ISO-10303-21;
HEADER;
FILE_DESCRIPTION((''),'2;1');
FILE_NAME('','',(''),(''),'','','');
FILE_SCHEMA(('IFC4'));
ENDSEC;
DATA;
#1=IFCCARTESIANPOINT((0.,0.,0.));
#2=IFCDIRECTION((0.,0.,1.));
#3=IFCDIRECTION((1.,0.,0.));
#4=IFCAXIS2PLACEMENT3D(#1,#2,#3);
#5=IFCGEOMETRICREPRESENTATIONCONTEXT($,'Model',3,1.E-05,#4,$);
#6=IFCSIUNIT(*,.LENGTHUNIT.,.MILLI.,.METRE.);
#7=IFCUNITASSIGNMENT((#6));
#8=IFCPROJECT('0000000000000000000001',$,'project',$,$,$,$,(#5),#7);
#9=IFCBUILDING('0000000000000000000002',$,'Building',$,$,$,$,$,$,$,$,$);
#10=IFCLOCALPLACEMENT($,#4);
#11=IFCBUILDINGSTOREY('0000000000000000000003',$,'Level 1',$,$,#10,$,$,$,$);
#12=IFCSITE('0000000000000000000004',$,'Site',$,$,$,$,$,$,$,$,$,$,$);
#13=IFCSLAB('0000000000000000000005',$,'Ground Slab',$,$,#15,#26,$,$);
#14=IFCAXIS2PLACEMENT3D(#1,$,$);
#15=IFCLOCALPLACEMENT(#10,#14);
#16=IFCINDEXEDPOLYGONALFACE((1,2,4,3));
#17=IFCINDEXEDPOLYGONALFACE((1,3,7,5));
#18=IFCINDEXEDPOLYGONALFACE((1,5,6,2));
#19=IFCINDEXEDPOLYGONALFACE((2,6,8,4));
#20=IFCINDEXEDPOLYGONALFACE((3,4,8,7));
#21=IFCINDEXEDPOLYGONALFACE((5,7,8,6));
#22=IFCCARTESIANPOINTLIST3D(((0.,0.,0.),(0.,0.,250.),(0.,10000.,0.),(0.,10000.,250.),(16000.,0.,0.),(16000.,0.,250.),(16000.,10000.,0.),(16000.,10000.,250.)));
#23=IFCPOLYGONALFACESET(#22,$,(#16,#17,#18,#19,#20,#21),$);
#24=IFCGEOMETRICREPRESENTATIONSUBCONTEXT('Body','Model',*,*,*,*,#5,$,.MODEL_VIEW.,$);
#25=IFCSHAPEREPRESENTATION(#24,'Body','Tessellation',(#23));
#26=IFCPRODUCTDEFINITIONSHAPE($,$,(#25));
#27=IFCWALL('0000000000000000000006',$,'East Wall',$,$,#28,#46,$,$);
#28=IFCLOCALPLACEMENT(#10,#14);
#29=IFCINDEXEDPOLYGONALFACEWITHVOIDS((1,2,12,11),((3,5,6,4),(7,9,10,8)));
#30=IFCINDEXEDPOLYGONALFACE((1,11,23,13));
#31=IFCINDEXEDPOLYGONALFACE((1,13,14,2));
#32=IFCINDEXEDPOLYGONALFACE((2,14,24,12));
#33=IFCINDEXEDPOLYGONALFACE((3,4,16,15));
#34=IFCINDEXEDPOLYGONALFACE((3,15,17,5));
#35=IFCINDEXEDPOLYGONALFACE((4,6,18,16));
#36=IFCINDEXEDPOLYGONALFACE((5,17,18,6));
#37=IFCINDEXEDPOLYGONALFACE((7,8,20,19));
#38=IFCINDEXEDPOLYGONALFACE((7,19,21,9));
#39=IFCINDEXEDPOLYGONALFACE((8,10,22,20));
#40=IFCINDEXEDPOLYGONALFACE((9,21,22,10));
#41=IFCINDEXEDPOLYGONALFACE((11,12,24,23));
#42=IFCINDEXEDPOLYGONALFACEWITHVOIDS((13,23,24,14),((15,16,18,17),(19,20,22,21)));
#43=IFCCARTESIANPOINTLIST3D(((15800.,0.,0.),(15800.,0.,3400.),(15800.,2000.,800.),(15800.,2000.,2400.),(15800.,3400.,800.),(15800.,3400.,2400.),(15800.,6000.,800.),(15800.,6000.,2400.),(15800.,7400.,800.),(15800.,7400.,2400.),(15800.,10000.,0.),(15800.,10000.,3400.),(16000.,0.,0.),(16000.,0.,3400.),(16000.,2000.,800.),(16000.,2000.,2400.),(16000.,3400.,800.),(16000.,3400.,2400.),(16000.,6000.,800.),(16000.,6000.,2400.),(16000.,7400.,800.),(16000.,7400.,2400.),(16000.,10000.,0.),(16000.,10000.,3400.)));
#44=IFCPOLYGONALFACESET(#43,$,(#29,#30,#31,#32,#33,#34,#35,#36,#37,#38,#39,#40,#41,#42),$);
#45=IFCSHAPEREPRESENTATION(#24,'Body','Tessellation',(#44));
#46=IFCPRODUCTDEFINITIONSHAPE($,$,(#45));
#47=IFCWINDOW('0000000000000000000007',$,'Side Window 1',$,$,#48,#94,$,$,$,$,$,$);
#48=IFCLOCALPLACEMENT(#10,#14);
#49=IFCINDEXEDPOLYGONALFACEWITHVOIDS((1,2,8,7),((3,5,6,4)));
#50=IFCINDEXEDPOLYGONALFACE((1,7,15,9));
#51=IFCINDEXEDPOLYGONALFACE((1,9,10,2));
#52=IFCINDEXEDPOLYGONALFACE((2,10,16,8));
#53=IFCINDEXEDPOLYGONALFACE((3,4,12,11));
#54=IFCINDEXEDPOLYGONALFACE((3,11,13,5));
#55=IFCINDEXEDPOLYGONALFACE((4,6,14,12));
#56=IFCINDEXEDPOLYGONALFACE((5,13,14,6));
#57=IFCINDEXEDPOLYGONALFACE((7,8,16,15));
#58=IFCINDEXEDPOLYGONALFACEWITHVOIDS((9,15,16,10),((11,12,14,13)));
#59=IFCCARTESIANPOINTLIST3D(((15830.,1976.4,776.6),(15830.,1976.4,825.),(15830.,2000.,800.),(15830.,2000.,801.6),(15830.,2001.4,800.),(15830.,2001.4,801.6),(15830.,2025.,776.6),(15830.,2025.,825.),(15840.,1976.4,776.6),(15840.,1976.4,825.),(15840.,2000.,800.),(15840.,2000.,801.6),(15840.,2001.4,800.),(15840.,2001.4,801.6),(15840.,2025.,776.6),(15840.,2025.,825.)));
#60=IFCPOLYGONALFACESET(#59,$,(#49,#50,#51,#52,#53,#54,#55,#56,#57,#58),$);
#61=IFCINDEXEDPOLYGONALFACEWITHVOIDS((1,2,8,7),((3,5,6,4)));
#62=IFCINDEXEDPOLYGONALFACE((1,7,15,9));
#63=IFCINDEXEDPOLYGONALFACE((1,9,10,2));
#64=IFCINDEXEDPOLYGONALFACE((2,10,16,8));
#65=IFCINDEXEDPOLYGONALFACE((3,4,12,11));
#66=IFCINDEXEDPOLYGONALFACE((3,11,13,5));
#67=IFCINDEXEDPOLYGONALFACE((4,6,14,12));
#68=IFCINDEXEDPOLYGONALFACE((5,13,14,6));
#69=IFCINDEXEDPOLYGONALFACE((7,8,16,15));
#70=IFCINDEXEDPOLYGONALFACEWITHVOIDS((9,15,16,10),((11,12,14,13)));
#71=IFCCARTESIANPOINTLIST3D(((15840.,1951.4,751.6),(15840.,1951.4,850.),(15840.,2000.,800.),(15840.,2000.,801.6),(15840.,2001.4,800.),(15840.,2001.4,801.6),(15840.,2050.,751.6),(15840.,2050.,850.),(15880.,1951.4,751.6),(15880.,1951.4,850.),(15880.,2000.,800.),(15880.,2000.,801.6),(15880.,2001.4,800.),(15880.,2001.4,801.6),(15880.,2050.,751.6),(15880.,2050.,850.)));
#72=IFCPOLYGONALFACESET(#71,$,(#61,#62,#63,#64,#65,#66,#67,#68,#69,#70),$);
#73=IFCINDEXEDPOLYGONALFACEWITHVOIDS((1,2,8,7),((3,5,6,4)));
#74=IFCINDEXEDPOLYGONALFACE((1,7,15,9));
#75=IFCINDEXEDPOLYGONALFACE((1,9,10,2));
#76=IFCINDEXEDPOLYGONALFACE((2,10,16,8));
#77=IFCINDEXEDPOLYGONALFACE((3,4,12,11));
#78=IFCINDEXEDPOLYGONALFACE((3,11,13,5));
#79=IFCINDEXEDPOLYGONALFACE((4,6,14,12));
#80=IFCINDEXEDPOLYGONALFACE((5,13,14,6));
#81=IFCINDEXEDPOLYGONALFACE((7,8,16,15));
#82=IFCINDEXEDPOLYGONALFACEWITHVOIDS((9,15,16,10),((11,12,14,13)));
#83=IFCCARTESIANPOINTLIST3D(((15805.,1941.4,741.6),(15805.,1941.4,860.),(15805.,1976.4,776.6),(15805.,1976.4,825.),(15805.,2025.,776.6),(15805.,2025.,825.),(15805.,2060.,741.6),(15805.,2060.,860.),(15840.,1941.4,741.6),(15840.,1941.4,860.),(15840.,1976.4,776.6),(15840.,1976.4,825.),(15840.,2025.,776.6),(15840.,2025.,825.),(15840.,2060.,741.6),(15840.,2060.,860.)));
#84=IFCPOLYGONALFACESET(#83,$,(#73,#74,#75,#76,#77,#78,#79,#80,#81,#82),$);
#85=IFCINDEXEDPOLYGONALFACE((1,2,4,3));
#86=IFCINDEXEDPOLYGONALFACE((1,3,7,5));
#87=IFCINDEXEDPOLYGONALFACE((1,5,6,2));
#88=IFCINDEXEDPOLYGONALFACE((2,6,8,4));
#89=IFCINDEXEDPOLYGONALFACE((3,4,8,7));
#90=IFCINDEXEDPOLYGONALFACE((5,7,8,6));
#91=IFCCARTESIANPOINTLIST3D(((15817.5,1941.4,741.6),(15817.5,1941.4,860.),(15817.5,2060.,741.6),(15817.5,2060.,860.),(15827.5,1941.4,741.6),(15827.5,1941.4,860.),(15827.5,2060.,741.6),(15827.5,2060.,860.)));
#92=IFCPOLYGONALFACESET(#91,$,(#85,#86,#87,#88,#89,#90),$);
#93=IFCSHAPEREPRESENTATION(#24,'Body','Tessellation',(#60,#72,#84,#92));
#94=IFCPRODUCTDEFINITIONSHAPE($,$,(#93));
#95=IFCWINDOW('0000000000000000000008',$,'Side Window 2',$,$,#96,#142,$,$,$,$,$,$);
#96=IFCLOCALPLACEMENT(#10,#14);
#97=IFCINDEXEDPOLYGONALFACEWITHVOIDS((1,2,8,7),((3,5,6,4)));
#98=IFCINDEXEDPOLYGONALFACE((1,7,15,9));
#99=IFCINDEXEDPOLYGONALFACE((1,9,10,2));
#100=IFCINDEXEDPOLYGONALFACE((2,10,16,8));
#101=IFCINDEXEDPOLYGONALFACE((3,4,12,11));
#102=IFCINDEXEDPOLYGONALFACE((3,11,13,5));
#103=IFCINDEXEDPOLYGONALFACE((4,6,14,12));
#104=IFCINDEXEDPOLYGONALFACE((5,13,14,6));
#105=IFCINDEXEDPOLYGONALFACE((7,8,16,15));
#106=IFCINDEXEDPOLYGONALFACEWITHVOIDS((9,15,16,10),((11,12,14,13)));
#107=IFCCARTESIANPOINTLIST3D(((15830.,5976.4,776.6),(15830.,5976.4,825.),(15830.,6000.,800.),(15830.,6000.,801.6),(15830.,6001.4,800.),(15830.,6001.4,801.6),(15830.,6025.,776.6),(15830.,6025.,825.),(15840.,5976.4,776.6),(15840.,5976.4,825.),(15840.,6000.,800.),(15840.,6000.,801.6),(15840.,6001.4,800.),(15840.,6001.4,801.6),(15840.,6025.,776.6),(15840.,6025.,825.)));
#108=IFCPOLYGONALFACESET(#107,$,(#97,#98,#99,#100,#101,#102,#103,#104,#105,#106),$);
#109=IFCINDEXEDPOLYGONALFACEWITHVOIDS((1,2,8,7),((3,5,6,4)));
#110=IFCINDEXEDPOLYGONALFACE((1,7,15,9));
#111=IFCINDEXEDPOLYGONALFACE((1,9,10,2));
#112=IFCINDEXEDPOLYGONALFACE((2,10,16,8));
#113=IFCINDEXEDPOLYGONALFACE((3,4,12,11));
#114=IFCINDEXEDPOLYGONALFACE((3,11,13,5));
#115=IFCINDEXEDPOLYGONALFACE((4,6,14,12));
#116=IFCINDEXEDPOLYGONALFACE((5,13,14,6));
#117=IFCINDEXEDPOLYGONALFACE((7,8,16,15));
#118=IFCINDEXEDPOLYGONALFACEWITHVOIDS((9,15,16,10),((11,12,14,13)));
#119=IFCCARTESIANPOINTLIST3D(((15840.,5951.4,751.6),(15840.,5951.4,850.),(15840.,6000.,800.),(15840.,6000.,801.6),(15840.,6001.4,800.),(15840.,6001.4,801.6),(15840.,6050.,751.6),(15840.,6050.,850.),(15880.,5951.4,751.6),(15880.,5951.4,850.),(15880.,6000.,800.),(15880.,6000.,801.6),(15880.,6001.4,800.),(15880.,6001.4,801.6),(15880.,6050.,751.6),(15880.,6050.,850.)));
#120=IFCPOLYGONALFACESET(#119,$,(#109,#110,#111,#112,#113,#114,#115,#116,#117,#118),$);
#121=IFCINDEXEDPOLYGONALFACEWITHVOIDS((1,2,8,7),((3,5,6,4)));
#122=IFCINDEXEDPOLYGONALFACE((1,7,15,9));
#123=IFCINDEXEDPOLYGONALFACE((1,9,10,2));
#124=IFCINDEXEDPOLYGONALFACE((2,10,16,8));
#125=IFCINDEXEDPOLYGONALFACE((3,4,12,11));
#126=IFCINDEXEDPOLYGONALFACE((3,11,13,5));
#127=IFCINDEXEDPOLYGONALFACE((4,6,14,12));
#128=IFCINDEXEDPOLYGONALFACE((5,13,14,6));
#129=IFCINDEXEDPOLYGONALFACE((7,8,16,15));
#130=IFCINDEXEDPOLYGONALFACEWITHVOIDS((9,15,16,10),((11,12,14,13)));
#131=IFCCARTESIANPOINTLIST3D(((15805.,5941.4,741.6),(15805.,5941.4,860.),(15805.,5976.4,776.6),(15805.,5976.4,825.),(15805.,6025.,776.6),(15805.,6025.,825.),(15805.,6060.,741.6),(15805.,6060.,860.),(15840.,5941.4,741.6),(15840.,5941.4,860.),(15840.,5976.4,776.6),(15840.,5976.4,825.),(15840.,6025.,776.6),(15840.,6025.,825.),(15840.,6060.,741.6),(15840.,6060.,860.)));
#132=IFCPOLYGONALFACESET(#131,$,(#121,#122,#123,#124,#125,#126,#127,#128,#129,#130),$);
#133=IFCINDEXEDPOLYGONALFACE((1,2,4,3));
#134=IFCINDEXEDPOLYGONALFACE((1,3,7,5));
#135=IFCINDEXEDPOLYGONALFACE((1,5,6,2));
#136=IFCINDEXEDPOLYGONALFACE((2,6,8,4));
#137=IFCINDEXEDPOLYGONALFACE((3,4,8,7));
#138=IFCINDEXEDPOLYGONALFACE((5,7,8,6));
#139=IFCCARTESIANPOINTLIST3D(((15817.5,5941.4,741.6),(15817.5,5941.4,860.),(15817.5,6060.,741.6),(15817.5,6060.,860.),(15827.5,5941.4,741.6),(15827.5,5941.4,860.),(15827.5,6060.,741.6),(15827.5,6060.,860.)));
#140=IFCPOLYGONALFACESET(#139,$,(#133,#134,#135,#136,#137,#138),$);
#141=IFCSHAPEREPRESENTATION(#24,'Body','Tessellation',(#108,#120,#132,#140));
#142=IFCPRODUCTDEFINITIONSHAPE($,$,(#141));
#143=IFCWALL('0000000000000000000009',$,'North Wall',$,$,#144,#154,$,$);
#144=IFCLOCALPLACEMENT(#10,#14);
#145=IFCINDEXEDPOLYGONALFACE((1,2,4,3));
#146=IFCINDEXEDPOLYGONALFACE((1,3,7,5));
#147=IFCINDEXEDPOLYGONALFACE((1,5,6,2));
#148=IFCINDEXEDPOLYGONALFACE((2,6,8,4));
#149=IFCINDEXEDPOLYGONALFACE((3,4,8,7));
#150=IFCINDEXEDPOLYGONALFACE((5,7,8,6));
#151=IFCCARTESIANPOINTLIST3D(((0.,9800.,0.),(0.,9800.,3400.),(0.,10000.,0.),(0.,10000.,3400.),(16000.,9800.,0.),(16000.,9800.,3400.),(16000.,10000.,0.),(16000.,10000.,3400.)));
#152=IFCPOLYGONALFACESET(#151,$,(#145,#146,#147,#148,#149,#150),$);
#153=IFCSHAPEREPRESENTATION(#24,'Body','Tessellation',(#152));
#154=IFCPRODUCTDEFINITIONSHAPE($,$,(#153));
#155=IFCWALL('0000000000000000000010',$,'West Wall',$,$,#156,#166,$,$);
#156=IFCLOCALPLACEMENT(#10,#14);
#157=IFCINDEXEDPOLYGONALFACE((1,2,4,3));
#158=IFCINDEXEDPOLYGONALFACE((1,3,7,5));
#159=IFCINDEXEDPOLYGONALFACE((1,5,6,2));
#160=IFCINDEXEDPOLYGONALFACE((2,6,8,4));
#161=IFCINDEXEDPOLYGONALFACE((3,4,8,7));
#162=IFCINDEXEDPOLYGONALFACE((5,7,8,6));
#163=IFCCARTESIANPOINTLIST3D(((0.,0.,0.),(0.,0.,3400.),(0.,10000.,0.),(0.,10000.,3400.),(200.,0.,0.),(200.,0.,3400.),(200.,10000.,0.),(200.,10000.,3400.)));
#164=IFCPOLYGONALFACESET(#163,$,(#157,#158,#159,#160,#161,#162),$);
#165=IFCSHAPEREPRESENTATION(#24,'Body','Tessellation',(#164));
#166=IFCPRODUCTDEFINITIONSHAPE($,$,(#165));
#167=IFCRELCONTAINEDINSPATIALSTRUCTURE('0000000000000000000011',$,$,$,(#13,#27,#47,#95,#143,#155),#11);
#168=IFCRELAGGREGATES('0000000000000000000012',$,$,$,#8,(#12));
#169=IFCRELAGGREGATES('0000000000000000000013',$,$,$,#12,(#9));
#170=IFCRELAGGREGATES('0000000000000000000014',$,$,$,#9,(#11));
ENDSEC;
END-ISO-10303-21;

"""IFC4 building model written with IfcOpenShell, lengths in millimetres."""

from ifc_helpers import new_model, si_unit, frame, origin_with_axes, place, context, subcontext, project, spatial, line, indexed_curve, outline, extrude, element, fill, save


model = new_model("IFC4")

# Units and contexts
model_context = context("Model", 3, precision=1e-05, world=origin_with_axes())
body_context = subcontext(model_context, "Body", "Model", "MODEL_VIEW")
ifc_project = project(units=[si_unit("LENGTHUNIT", "METRE", prefix="MILLI")], contexts=[model_context])

# Site, building, storey
site = spatial("IfcSite", under=ifc_project, Name="Site")
building = spatial("IfcBuilding", under=site, Name="Building")
storey_placement = place(None, origin_with_axes())
storey = spatial("IfcBuildingStorey", under=building, at=storey_placement, Name="Level 1")

# Slab
slab_placement = place(storey_placement, origin_with_axes())
element("IfcSlab", 1, at=slab_placement, inside=storey, Name="Ground Slab", context=body_context, shape_type="SweptSolid", body=[
    extrude(outline(indexed_curve([(0.0, 0.0), (16000.0, 0.0), (16000.0, 10000.0), (0.0, 10000.0), (0.0, 0.0)])), None, (0.0, 0.0, 1.0), 250.0),
])

# Wall, openings, windows
wall_1_placement = place(storey_placement, frame((16000.0, 0.0, 0.0), z_axis=(0.0, 0.0, 1.0), x_axis=(0.0, 1.0, 0.0)))
wall_1 = element("IfcWall", 2, at=wall_1_placement, inside=storey, Name="East Wall", context=body_context, shape_type="SweptSolid", body=[
    extrude(outline(indexed_curve([(0.0, 0.0), (0.0, 200.0), (10000.0, 200.0), (10000.0, 0.0), (0.0, 0.0)], self_intersect=False)), origin_with_axes(), (0.0, 0.0, 1.0), 3400.0),
])
opening_1_placement = place(wall_1_placement, frame((2000.0, -100.0, 800.0), z_axis=(0.0, 0.0, 1.0), x_axis=(1.0, 0.0, 0.0)))
opening_1 = element("IfcOpeningElement", 3, at=opening_1_placement, cuts=wall_1, context=body_context, shape_type="SweptSolid", body=[
    extrude(outline(indexed_curve([(0.0, 0.0), (0.0, 400.0), (1400.0, 400.0), (1400.0, 0.0), (0.0, 0.0)], self_intersect=False)), origin_with_axes(), (0.0, 0.0, 1.0), 1600.0),
])
opening_2_placement = place(wall_1_placement, frame((6000.0, -100.0, 800.0), z_axis=(0.0, 0.0, 1.0), x_axis=(1.0, 0.0, 0.0)))
opening_2 = element("IfcOpeningElement", 4, at=opening_2_placement, cuts=wall_1, context=body_context, shape_type="SweptSolid", body=[
    extrude(outline(indexed_curve([(0.0, 0.0), (0.0, 400.0), (1400.0, 400.0), (1400.0, 0.0), (0.0, 0.0)], self_intersect=False)), origin_with_axes(), (0.0, 0.0, 1.0), 1600.0),
])
window_1_placement = place(opening_1_placement, frame((0.0, 170.0, 0.0), z_axis=(0.0, 0.0, 1.0), x_axis=(1.0, 0.0, 0.0)))
window_1 = element("IfcWindow", 5, at=window_1_placement, inside=storey, Name="Side Window 1", context=body_context, shape_type="SweptSolid", body=[
    extrude(outline(indexed_curve([(0.0, 0.0), (1.4, 0.0), (1.4, 1.6), (0.0, 1.6)], segments=[line(1, 2, 3, 4, 1)]), holes=[indexed_curve([(25.0, 25.0), (-23.6, 25.0), (-23.6, -23.4), (25.0, -23.4)], segments=[line(1, 2, 3, 4, 1)])]), frame((0.0, 90.0, 0.0), z_axis=(0.0, -1.0, 0.0), x_axis=(1.0, 0.0, 0.0)), (0.0, 0.0, -1.0), 10.0),
    extrude(outline(indexed_curve([(0.0, 0.0), (1.4, 0.0), (1.4, 1.6), (0.0, 1.6)], segments=[line(1, 2, 3, 4, 1)]), holes=[indexed_curve([(50.0, 50.0), (-48.6, 50.0), (-48.6, -48.4), (50.0, -48.4)], segments=[line(1, 2, 3, 4, 1)])]), frame((0.0, 50.0, 0.0), z_axis=(0.0, -1.0, 0.0), x_axis=(1.0, 0.0, 0.0)), (0.0, 0.0, -1.0), 40.0),
    extrude(outline(indexed_curve([(0.0, 0.0), (-48.6, 0.0), (-48.6, -48.4), (0.0, -48.4)], segments=[line(1, 2, 3, 4, 1)]), holes=[indexed_curve([(35.0, 35.0), (-83.6, 35.0), (-83.6, -83.4), (35.0, -83.4)], segments=[line(1, 2, 3, 4, 1)])]), frame((25.0, 90.0, 25.0), z_axis=(0.0, -1.0, 0.0), x_axis=(1.0, 0.0, 0.0)), (0.0, 0.0, -1.0), 35.0),
    extrude(outline(indexed_curve([(35.0, 35.0), (-83.6, 35.0), (-83.6, -83.4), (35.0, -83.4)], segments=[line(1, 2, 3, 4, 1)])), frame((25.0, 102.5, 25.0), z_axis=(0.0, -1.0, 0.0), x_axis=(1.0, 0.0, 0.0)), (0.0, 0.0, -1.0), 10.0),
])
fill(opening_1, window_1)
window_2_placement = place(opening_2_placement, frame((0.0, 170.0, 0.0), z_axis=(0.0, 0.0, 1.0), x_axis=(1.0, 0.0, 0.0)))
window_2 = element("IfcWindow", 6, at=window_2_placement, inside=storey, Name="Side Window 2", context=body_context, shape_type="SweptSolid", body=[
    extrude(outline(indexed_curve([(0.0, 0.0), (1.4, 0.0), (1.4, 1.6), (0.0, 1.6)], segments=[line(1, 2, 3, 4, 1)]), holes=[indexed_curve([(25.0, 25.0), (-23.6, 25.0), (-23.6, -23.4), (25.0, -23.4)], segments=[line(1, 2, 3, 4, 1)])]), frame((0.0, 90.0, 0.0), z_axis=(0.0, -1.0, 0.0), x_axis=(1.0, 0.0, 0.0)), (0.0, 0.0, -1.0), 10.0),
    extrude(outline(indexed_curve([(0.0, 0.0), (1.4, 0.0), (1.4, 1.6), (0.0, 1.6)], segments=[line(1, 2, 3, 4, 1)]), holes=[indexed_curve([(50.0, 50.0), (-48.6, 50.0), (-48.6, -48.4), (50.0, -48.4)], segments=[line(1, 2, 3, 4, 1)])]), frame((0.0, 50.0, 0.0), z_axis=(0.0, -1.0, 0.0), x_axis=(1.0, 0.0, 0.0)), (0.0, 0.0, -1.0), 40.0),
    extrude(outline(indexed_curve([(0.0, 0.0), (-48.6, 0.0), (-48.6, -48.4), (0.0, -48.4)], segments=[line(1, 2, 3, 4, 1)]), holes=[indexed_curve([(35.0, 35.0), (-83.6, 35.0), (-83.6, -83.4), (35.0, -83.4)], segments=[line(1, 2, 3, 4, 1)])]), frame((25.0, 90.0, 25.0), z_axis=(0.0, -1.0, 0.0), x_axis=(1.0, 0.0, 0.0)), (0.0, 0.0, -1.0), 35.0),
    extrude(outline(indexed_curve([(35.0, 35.0), (-83.6, 35.0), (-83.6, -83.4), (35.0, -83.4)], segments=[line(1, 2, 3, 4, 1)])), frame((25.0, 102.5, 25.0), z_axis=(0.0, -1.0, 0.0), x_axis=(1.0, 0.0, 0.0)), (0.0, 0.0, -1.0), 10.0),
])
fill(opening_2, window_2)

# Walls
wall_2_placement = place(storey_placement, frame((16000.0, 10000.0, 0.0), z_axis=(0.0, 0.0, 1.0), x_axis=(-1.0, 0.0, 0.0)))
element("IfcWall", 7, at=wall_2_placement, inside=storey, Name="North Wall", context=body_context, shape_type="SweptSolid", body=[
    extrude(outline(indexed_curve([(0.0, 0.0), (0.0, 200.0), (16000.0, 200.0), (16000.0, 0.0), (0.0, 0.0)], self_intersect=False)), origin_with_axes(), (0.0, 0.0, 1.0), 3400.0),
])
wall_3_placement = place(storey_placement, frame((0.0, 10000.0, 0.0), z_axis=(0.0, 0.0, 1.0), x_axis=(0.0, -1.0, 0.0)))
element("IfcWall", 8, at=wall_3_placement, inside=storey, Name="West Wall", context=body_context, shape_type="SweptSolid", body=[
    extrude(outline(indexed_curve([(0.0, 0.0), (0.0, 200.0), (10000.0, 200.0), (10000.0, 0.0), (0.0, 0.0)], self_intersect=False)), origin_with_axes(), (0.0, 0.0, 1.0), 3400.0),
])

save(model, "model.ifc")
